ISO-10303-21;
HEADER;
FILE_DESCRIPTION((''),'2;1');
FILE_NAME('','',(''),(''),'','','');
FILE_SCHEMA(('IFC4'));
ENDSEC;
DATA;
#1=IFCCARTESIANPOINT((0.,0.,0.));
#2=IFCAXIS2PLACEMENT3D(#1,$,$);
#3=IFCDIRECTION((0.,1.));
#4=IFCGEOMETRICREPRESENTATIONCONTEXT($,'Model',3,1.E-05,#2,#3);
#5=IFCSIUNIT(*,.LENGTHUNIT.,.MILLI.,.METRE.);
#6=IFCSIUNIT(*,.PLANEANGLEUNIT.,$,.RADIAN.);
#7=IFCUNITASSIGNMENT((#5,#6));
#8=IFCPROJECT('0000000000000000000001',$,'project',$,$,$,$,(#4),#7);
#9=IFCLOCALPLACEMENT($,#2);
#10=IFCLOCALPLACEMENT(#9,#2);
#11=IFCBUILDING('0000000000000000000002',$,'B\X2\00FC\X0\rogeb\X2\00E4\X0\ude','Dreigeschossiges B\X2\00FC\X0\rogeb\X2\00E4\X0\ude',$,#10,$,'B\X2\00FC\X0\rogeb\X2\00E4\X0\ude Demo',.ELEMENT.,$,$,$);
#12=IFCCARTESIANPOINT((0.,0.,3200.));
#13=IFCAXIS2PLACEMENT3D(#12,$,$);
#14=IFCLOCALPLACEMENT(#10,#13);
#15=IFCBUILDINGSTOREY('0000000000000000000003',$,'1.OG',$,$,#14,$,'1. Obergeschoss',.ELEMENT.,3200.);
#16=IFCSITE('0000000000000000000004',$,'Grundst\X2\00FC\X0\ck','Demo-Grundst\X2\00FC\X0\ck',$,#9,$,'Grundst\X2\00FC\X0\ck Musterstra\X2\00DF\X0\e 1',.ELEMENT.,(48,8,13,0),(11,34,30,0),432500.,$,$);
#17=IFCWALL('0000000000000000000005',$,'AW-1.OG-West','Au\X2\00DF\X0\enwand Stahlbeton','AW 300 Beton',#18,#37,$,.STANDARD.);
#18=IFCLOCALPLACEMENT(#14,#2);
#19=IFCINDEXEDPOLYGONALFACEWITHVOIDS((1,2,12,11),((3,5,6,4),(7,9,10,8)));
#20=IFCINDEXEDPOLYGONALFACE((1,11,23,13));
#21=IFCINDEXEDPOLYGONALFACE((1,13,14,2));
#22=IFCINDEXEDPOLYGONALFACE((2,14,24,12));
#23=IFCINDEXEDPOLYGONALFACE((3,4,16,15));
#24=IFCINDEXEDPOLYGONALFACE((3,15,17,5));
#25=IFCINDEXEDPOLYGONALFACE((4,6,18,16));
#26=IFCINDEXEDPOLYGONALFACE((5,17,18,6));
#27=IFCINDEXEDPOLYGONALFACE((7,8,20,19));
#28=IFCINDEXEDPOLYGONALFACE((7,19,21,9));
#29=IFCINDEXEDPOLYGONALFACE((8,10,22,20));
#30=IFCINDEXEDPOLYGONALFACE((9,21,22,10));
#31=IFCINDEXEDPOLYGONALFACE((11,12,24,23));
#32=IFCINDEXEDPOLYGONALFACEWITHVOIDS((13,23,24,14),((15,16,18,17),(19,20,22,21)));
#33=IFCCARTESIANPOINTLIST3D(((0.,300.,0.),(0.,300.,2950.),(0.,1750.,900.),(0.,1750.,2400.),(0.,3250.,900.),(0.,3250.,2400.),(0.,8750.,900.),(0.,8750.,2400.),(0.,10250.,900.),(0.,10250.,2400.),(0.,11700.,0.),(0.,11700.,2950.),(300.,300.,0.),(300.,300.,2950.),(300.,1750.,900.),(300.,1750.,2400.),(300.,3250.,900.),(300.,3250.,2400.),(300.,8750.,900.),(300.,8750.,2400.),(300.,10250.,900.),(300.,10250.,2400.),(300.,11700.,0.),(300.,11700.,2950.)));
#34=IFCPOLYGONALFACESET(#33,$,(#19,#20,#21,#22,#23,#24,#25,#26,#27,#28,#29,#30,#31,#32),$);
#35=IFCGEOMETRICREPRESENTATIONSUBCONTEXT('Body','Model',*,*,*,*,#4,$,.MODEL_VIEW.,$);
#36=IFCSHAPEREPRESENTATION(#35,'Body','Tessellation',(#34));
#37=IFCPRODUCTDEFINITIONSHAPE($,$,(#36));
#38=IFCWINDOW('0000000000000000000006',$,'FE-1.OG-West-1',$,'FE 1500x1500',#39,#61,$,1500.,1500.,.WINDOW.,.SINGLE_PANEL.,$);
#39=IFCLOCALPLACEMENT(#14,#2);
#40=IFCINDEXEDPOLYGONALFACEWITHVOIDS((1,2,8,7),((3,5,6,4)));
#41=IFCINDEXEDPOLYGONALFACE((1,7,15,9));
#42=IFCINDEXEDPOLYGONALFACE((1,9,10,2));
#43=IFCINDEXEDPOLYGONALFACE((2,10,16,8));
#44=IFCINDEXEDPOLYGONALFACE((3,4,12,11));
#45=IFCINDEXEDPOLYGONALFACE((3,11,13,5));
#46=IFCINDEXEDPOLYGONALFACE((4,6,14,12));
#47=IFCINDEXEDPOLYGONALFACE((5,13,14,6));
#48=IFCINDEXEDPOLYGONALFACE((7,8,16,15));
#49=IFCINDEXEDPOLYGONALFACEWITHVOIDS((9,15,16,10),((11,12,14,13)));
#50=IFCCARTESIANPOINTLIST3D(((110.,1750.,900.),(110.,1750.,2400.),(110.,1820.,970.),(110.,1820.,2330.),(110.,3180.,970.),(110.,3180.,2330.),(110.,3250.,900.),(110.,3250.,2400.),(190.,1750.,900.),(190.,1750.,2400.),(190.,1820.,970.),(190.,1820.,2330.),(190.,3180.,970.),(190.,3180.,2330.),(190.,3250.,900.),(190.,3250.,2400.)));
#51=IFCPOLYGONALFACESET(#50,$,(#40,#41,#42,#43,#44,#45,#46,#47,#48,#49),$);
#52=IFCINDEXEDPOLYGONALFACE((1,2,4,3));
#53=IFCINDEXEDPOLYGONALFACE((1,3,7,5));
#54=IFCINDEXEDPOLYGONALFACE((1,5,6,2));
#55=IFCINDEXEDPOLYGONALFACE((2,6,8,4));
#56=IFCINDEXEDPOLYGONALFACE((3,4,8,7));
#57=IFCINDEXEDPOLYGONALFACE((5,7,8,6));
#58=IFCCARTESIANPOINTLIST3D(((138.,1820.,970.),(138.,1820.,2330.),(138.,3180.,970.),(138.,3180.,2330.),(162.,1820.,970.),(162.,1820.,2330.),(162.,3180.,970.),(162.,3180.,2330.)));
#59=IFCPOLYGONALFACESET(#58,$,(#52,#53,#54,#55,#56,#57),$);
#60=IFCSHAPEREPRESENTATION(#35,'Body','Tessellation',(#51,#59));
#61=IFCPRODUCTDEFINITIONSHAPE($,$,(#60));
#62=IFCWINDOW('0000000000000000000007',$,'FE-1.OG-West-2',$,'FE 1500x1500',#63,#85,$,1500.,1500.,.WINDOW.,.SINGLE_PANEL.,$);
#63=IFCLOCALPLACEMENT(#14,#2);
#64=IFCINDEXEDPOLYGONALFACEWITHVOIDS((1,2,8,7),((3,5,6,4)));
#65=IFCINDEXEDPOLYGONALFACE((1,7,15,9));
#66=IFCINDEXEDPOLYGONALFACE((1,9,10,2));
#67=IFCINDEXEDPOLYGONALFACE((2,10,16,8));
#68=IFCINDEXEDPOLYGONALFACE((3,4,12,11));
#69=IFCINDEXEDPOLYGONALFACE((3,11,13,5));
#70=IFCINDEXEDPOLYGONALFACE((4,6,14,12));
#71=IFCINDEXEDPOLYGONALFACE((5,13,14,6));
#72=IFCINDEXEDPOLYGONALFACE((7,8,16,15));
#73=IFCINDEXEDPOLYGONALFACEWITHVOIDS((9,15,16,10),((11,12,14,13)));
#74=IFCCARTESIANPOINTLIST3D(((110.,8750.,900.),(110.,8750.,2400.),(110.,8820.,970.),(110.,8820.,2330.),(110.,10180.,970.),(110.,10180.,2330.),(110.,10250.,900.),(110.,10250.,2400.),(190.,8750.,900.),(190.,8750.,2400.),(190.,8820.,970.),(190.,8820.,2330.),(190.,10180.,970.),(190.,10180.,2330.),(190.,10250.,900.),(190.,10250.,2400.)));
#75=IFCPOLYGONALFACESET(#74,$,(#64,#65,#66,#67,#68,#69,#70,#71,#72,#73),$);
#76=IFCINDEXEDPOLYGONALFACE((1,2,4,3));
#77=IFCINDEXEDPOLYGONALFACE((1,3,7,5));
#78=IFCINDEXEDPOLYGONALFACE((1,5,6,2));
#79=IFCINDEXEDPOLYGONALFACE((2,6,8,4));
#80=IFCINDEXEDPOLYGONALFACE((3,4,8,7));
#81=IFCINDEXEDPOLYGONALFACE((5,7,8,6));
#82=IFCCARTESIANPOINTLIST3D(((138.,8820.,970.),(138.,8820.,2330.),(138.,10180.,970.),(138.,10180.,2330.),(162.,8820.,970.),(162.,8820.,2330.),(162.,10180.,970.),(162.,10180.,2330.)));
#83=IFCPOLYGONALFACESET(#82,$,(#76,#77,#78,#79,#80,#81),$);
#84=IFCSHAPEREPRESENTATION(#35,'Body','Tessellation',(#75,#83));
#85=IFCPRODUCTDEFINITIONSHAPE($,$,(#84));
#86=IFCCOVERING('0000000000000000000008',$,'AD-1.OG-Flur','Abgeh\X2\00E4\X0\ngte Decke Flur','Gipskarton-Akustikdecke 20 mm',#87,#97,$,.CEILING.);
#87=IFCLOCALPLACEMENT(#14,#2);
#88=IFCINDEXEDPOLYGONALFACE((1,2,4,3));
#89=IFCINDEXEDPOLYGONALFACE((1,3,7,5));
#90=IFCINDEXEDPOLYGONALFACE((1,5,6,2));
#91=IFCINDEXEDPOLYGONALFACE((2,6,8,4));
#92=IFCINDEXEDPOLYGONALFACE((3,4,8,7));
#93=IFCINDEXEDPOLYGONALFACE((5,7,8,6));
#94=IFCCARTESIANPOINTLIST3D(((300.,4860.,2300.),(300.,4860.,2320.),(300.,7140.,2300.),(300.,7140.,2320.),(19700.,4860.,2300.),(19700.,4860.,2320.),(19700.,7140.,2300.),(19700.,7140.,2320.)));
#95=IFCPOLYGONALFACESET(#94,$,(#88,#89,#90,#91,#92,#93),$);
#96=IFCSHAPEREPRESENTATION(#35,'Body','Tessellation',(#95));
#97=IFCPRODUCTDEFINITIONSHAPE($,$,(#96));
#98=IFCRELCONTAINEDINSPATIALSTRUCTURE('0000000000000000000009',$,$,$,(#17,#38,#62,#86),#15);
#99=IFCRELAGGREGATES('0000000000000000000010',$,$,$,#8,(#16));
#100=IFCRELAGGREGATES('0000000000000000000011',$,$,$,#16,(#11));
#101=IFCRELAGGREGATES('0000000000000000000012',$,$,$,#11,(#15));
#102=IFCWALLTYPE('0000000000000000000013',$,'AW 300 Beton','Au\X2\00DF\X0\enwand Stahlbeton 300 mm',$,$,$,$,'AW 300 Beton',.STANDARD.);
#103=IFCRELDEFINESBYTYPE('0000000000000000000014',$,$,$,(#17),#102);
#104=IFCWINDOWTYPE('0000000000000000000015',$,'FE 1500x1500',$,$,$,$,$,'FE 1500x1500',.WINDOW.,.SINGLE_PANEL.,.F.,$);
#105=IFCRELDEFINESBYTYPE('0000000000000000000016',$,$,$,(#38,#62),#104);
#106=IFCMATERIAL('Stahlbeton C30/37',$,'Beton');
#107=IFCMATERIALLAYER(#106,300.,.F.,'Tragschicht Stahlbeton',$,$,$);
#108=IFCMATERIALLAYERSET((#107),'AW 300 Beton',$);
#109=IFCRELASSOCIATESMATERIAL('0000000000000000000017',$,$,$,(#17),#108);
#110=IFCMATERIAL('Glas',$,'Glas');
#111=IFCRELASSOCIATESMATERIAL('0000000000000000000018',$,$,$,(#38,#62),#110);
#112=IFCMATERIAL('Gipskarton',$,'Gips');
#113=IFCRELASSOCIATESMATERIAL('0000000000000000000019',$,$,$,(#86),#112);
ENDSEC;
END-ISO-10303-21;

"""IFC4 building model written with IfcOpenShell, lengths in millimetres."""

from ifc_helpers import new_model, si_unit, direction, frame, frame_2d, origin, origin_2d, place, context, subcontext, project, spatial, polyline, rectangle, outline, extrude, material, layer, layer_set, layer_usage, type_object, element, fill, save


model = new_model("IFC4")

# Units and contexts
model_context = context("Model", 3, precision=1e-05, world=origin(), true_north=direction((0.0, 1.0)))
body_context = subcontext(model_context, "Body", "Model", "MODEL_VIEW")
ifc_project = project(units=[si_unit("LENGTHUNIT", "METRE", prefix="MILLI"), si_unit("PLANEANGLEUNIT", "RADIAN")], contexts=[model_context])

# Site, building, storey
site_placement = place(None, origin())
site = spatial("IfcSite", under=ifc_project, at=site_placement, Name="Grundstück", Description="Demo-Grundstück", LongName="Grundstück Musterstraße 1", CompositionType="ELEMENT", RefLatitude=(48, 8, 13, 0), RefLongitude=(11, 34, 30, 0), RefElevation=432500.0)
building_placement = place(site_placement, origin())
building = spatial("IfcBuilding", under=site, at=building_placement, Name="Bürogebäude", Description="Dreigeschossiges Bürogebäude", LongName="Bürogebäude Demo", CompositionType="ELEMENT")
storey_placement = place(building_placement, frame((0.0, 0.0, 3200.0)))
storey = spatial("IfcBuildingStorey", under=building, at=storey_placement, Name="1.OG", LongName="1. Obergeschoss", CompositionType="ELEMENT", Elevation=3200.0)

# Shared definitions
ifc_material_1 = material(Name="Stahlbeton C30/37", Category="Beton")

# Wall, openings, windows
ifc_layer = layer(ifc_material_1, 300.0, ventilated=False, Name="Tragschicht Stahlbeton")
ifc_layer_set = layer_set([ifc_layer], Name="AW 300 Beton")
ifc_layer_usage = layer_usage(ifc_layer_set, "AXIS2", "POSITIVE", -150.0)
wall_type = type_object("IfcWallType", Name="AW 300 Beton", Description="Außenwand Stahlbeton 300 mm", ElementType="AW 300 Beton", PredefinedType="STANDARD")
ifc_material_2 = material(Name="Glas", Category="Glas")
window_type = type_object("IfcWindowType", Name="FE 1500x1500", ElementType="FE 1500x1500", ParameterTakesPrecedence=False, PartitioningType="SINGLE_PANEL", PredefinedType="WINDOW")
wall_1_placement = place(storey_placement, frame((150.0, 300.0, 0.0), z_axis=(0.0, 0.0, 1.0), x_axis=(0.0, 1.0, 0.0)))
wall_1 = element("IfcWall", 1, at=wall_1_placement, inside=storey, type_object=wall_type, material=ifc_layer_usage, Name="AW-1.OG-West", Description="Außenwand Stahlbeton", ObjectType="AW 300 Beton", PredefinedType="STANDARD", context=body_context, shape_type="SweptSolid", body=[
    extrude(rectangle(XDim=11400.0, YDim=300.0, at=frame_2d((5700.0, 0.0))), origin(), (0.0, 0.0, 1.0), 2950.0),
])
opening_1_placement = place(wall_1_placement, frame((2200.0, 0.0, 900.0)))
opening_1 = element("IfcOpeningElement", 2, at=opening_1_placement, cuts=wall_1, PredefinedType="OPENING", context=body_context, shape_type="SweptSolid", body=[
    extrude(rectangle(XDim=1500.0, YDim=340.0, at=origin_2d()), origin(), (0.0, 0.0, 1.0), 1500.0),
])
opening_2_placement = place(wall_1_placement, frame((9200.0, 0.0, 900.0)))
opening_2 = element("IfcOpeningElement", 3, at=opening_2_placement, cuts=wall_1, PredefinedType="OPENING", context=body_context, shape_type="SweptSolid", body=[
    extrude(rectangle(XDim=1500.0, YDim=340.0, at=origin_2d()), origin(), (0.0, 0.0, 1.0), 1500.0),
])
window_1_placement = place(opening_1_placement, origin())
window_1 = element("IfcWindow", 4, at=window_1_placement, inside=storey, type_object=window_type, material=ifc_material_2, Name="FE-1.OG-West-1", ObjectType="FE 1500x1500", OverallHeight=1500.0, OverallWidth=1500.0, PartitioningType="SINGLE_PANEL", PredefinedType="WINDOW", context=body_context, shape_type="SweptSolid", body=[
    extrude(outline(polyline([(-750.0, 0.0), (750.0, 0.0), (750.0, 1500.0), (-750.0, 1500.0), (-750.0, 0.0)]), holes=[polyline([(-680.0, 70.0), (680.0, 70.0), (680.0, 1430.0), (-680.0, 1430.0), (-680.0, 70.0)])]), frame((0.0, 40.0, 0.0), z_axis=(0.0, -1.0, 0.0), x_axis=(1.0, 0.0, 0.0)), (0.0, 0.0, 1.0), 80.0),
    extrude(rectangle(XDim=1360.0, YDim=24.0, at=origin_2d()), frame((0.0, 0.0, 70.0)), (0.0, 0.0, 1.0), 1360.0),
])
fill(opening_1, window_1)
window_2_placement = place(opening_2_placement, origin())
window_2 = element("IfcWindow", 5, at=window_2_placement, inside=storey, type_object=window_type, material=ifc_material_2, Name="FE-1.OG-West-2", ObjectType="FE 1500x1500", OverallHeight=1500.0, OverallWidth=1500.0, PartitioningType="SINGLE_PANEL", PredefinedType="WINDOW", context=body_context, shape_type="SweptSolid", body=[
    extrude(outline(polyline([(-750.0, 0.0), (750.0, 0.0), (750.0, 1500.0), (-750.0, 1500.0), (-750.0, 0.0)]), holes=[polyline([(-680.0, 70.0), (680.0, 70.0), (680.0, 1430.0), (-680.0, 1430.0), (-680.0, 70.0)])]), frame((0.0, 40.0, 0.0), z_axis=(0.0, -1.0, 0.0), x_axis=(1.0, 0.0, 0.0)), (0.0, 0.0, 1.0), 80.0),
    extrude(rectangle(XDim=1360.0, YDim=24.0, at=origin_2d()), frame((0.0, 0.0, 70.0)), (0.0, 0.0, 1.0), 1360.0),
])
fill(opening_2, window_2)

# Covering
ifc_material_3 = material(Name="Gipskarton", Category="Gips")
covering_placement = place(storey_placement, origin())
element("IfcCovering", 6, at=covering_placement, inside=storey, material=ifc_material_3, Name="AD-1.OG-Flur", Description="Abgehängte Decke Flur", ObjectType="Gipskarton-Akustikdecke 20 mm", PredefinedType="CEILING", context=body_context, shape_type="SweptSolid", body=[
    extrude(rectangle(XDim=19400.0, YDim=2280.0, at=frame_2d((10000.0, 6000.0))), frame((0.0, 0.0, 2300.0)), (0.0, 0.0, 1.0), 20.0),
])

save(model, "model.ifc")
